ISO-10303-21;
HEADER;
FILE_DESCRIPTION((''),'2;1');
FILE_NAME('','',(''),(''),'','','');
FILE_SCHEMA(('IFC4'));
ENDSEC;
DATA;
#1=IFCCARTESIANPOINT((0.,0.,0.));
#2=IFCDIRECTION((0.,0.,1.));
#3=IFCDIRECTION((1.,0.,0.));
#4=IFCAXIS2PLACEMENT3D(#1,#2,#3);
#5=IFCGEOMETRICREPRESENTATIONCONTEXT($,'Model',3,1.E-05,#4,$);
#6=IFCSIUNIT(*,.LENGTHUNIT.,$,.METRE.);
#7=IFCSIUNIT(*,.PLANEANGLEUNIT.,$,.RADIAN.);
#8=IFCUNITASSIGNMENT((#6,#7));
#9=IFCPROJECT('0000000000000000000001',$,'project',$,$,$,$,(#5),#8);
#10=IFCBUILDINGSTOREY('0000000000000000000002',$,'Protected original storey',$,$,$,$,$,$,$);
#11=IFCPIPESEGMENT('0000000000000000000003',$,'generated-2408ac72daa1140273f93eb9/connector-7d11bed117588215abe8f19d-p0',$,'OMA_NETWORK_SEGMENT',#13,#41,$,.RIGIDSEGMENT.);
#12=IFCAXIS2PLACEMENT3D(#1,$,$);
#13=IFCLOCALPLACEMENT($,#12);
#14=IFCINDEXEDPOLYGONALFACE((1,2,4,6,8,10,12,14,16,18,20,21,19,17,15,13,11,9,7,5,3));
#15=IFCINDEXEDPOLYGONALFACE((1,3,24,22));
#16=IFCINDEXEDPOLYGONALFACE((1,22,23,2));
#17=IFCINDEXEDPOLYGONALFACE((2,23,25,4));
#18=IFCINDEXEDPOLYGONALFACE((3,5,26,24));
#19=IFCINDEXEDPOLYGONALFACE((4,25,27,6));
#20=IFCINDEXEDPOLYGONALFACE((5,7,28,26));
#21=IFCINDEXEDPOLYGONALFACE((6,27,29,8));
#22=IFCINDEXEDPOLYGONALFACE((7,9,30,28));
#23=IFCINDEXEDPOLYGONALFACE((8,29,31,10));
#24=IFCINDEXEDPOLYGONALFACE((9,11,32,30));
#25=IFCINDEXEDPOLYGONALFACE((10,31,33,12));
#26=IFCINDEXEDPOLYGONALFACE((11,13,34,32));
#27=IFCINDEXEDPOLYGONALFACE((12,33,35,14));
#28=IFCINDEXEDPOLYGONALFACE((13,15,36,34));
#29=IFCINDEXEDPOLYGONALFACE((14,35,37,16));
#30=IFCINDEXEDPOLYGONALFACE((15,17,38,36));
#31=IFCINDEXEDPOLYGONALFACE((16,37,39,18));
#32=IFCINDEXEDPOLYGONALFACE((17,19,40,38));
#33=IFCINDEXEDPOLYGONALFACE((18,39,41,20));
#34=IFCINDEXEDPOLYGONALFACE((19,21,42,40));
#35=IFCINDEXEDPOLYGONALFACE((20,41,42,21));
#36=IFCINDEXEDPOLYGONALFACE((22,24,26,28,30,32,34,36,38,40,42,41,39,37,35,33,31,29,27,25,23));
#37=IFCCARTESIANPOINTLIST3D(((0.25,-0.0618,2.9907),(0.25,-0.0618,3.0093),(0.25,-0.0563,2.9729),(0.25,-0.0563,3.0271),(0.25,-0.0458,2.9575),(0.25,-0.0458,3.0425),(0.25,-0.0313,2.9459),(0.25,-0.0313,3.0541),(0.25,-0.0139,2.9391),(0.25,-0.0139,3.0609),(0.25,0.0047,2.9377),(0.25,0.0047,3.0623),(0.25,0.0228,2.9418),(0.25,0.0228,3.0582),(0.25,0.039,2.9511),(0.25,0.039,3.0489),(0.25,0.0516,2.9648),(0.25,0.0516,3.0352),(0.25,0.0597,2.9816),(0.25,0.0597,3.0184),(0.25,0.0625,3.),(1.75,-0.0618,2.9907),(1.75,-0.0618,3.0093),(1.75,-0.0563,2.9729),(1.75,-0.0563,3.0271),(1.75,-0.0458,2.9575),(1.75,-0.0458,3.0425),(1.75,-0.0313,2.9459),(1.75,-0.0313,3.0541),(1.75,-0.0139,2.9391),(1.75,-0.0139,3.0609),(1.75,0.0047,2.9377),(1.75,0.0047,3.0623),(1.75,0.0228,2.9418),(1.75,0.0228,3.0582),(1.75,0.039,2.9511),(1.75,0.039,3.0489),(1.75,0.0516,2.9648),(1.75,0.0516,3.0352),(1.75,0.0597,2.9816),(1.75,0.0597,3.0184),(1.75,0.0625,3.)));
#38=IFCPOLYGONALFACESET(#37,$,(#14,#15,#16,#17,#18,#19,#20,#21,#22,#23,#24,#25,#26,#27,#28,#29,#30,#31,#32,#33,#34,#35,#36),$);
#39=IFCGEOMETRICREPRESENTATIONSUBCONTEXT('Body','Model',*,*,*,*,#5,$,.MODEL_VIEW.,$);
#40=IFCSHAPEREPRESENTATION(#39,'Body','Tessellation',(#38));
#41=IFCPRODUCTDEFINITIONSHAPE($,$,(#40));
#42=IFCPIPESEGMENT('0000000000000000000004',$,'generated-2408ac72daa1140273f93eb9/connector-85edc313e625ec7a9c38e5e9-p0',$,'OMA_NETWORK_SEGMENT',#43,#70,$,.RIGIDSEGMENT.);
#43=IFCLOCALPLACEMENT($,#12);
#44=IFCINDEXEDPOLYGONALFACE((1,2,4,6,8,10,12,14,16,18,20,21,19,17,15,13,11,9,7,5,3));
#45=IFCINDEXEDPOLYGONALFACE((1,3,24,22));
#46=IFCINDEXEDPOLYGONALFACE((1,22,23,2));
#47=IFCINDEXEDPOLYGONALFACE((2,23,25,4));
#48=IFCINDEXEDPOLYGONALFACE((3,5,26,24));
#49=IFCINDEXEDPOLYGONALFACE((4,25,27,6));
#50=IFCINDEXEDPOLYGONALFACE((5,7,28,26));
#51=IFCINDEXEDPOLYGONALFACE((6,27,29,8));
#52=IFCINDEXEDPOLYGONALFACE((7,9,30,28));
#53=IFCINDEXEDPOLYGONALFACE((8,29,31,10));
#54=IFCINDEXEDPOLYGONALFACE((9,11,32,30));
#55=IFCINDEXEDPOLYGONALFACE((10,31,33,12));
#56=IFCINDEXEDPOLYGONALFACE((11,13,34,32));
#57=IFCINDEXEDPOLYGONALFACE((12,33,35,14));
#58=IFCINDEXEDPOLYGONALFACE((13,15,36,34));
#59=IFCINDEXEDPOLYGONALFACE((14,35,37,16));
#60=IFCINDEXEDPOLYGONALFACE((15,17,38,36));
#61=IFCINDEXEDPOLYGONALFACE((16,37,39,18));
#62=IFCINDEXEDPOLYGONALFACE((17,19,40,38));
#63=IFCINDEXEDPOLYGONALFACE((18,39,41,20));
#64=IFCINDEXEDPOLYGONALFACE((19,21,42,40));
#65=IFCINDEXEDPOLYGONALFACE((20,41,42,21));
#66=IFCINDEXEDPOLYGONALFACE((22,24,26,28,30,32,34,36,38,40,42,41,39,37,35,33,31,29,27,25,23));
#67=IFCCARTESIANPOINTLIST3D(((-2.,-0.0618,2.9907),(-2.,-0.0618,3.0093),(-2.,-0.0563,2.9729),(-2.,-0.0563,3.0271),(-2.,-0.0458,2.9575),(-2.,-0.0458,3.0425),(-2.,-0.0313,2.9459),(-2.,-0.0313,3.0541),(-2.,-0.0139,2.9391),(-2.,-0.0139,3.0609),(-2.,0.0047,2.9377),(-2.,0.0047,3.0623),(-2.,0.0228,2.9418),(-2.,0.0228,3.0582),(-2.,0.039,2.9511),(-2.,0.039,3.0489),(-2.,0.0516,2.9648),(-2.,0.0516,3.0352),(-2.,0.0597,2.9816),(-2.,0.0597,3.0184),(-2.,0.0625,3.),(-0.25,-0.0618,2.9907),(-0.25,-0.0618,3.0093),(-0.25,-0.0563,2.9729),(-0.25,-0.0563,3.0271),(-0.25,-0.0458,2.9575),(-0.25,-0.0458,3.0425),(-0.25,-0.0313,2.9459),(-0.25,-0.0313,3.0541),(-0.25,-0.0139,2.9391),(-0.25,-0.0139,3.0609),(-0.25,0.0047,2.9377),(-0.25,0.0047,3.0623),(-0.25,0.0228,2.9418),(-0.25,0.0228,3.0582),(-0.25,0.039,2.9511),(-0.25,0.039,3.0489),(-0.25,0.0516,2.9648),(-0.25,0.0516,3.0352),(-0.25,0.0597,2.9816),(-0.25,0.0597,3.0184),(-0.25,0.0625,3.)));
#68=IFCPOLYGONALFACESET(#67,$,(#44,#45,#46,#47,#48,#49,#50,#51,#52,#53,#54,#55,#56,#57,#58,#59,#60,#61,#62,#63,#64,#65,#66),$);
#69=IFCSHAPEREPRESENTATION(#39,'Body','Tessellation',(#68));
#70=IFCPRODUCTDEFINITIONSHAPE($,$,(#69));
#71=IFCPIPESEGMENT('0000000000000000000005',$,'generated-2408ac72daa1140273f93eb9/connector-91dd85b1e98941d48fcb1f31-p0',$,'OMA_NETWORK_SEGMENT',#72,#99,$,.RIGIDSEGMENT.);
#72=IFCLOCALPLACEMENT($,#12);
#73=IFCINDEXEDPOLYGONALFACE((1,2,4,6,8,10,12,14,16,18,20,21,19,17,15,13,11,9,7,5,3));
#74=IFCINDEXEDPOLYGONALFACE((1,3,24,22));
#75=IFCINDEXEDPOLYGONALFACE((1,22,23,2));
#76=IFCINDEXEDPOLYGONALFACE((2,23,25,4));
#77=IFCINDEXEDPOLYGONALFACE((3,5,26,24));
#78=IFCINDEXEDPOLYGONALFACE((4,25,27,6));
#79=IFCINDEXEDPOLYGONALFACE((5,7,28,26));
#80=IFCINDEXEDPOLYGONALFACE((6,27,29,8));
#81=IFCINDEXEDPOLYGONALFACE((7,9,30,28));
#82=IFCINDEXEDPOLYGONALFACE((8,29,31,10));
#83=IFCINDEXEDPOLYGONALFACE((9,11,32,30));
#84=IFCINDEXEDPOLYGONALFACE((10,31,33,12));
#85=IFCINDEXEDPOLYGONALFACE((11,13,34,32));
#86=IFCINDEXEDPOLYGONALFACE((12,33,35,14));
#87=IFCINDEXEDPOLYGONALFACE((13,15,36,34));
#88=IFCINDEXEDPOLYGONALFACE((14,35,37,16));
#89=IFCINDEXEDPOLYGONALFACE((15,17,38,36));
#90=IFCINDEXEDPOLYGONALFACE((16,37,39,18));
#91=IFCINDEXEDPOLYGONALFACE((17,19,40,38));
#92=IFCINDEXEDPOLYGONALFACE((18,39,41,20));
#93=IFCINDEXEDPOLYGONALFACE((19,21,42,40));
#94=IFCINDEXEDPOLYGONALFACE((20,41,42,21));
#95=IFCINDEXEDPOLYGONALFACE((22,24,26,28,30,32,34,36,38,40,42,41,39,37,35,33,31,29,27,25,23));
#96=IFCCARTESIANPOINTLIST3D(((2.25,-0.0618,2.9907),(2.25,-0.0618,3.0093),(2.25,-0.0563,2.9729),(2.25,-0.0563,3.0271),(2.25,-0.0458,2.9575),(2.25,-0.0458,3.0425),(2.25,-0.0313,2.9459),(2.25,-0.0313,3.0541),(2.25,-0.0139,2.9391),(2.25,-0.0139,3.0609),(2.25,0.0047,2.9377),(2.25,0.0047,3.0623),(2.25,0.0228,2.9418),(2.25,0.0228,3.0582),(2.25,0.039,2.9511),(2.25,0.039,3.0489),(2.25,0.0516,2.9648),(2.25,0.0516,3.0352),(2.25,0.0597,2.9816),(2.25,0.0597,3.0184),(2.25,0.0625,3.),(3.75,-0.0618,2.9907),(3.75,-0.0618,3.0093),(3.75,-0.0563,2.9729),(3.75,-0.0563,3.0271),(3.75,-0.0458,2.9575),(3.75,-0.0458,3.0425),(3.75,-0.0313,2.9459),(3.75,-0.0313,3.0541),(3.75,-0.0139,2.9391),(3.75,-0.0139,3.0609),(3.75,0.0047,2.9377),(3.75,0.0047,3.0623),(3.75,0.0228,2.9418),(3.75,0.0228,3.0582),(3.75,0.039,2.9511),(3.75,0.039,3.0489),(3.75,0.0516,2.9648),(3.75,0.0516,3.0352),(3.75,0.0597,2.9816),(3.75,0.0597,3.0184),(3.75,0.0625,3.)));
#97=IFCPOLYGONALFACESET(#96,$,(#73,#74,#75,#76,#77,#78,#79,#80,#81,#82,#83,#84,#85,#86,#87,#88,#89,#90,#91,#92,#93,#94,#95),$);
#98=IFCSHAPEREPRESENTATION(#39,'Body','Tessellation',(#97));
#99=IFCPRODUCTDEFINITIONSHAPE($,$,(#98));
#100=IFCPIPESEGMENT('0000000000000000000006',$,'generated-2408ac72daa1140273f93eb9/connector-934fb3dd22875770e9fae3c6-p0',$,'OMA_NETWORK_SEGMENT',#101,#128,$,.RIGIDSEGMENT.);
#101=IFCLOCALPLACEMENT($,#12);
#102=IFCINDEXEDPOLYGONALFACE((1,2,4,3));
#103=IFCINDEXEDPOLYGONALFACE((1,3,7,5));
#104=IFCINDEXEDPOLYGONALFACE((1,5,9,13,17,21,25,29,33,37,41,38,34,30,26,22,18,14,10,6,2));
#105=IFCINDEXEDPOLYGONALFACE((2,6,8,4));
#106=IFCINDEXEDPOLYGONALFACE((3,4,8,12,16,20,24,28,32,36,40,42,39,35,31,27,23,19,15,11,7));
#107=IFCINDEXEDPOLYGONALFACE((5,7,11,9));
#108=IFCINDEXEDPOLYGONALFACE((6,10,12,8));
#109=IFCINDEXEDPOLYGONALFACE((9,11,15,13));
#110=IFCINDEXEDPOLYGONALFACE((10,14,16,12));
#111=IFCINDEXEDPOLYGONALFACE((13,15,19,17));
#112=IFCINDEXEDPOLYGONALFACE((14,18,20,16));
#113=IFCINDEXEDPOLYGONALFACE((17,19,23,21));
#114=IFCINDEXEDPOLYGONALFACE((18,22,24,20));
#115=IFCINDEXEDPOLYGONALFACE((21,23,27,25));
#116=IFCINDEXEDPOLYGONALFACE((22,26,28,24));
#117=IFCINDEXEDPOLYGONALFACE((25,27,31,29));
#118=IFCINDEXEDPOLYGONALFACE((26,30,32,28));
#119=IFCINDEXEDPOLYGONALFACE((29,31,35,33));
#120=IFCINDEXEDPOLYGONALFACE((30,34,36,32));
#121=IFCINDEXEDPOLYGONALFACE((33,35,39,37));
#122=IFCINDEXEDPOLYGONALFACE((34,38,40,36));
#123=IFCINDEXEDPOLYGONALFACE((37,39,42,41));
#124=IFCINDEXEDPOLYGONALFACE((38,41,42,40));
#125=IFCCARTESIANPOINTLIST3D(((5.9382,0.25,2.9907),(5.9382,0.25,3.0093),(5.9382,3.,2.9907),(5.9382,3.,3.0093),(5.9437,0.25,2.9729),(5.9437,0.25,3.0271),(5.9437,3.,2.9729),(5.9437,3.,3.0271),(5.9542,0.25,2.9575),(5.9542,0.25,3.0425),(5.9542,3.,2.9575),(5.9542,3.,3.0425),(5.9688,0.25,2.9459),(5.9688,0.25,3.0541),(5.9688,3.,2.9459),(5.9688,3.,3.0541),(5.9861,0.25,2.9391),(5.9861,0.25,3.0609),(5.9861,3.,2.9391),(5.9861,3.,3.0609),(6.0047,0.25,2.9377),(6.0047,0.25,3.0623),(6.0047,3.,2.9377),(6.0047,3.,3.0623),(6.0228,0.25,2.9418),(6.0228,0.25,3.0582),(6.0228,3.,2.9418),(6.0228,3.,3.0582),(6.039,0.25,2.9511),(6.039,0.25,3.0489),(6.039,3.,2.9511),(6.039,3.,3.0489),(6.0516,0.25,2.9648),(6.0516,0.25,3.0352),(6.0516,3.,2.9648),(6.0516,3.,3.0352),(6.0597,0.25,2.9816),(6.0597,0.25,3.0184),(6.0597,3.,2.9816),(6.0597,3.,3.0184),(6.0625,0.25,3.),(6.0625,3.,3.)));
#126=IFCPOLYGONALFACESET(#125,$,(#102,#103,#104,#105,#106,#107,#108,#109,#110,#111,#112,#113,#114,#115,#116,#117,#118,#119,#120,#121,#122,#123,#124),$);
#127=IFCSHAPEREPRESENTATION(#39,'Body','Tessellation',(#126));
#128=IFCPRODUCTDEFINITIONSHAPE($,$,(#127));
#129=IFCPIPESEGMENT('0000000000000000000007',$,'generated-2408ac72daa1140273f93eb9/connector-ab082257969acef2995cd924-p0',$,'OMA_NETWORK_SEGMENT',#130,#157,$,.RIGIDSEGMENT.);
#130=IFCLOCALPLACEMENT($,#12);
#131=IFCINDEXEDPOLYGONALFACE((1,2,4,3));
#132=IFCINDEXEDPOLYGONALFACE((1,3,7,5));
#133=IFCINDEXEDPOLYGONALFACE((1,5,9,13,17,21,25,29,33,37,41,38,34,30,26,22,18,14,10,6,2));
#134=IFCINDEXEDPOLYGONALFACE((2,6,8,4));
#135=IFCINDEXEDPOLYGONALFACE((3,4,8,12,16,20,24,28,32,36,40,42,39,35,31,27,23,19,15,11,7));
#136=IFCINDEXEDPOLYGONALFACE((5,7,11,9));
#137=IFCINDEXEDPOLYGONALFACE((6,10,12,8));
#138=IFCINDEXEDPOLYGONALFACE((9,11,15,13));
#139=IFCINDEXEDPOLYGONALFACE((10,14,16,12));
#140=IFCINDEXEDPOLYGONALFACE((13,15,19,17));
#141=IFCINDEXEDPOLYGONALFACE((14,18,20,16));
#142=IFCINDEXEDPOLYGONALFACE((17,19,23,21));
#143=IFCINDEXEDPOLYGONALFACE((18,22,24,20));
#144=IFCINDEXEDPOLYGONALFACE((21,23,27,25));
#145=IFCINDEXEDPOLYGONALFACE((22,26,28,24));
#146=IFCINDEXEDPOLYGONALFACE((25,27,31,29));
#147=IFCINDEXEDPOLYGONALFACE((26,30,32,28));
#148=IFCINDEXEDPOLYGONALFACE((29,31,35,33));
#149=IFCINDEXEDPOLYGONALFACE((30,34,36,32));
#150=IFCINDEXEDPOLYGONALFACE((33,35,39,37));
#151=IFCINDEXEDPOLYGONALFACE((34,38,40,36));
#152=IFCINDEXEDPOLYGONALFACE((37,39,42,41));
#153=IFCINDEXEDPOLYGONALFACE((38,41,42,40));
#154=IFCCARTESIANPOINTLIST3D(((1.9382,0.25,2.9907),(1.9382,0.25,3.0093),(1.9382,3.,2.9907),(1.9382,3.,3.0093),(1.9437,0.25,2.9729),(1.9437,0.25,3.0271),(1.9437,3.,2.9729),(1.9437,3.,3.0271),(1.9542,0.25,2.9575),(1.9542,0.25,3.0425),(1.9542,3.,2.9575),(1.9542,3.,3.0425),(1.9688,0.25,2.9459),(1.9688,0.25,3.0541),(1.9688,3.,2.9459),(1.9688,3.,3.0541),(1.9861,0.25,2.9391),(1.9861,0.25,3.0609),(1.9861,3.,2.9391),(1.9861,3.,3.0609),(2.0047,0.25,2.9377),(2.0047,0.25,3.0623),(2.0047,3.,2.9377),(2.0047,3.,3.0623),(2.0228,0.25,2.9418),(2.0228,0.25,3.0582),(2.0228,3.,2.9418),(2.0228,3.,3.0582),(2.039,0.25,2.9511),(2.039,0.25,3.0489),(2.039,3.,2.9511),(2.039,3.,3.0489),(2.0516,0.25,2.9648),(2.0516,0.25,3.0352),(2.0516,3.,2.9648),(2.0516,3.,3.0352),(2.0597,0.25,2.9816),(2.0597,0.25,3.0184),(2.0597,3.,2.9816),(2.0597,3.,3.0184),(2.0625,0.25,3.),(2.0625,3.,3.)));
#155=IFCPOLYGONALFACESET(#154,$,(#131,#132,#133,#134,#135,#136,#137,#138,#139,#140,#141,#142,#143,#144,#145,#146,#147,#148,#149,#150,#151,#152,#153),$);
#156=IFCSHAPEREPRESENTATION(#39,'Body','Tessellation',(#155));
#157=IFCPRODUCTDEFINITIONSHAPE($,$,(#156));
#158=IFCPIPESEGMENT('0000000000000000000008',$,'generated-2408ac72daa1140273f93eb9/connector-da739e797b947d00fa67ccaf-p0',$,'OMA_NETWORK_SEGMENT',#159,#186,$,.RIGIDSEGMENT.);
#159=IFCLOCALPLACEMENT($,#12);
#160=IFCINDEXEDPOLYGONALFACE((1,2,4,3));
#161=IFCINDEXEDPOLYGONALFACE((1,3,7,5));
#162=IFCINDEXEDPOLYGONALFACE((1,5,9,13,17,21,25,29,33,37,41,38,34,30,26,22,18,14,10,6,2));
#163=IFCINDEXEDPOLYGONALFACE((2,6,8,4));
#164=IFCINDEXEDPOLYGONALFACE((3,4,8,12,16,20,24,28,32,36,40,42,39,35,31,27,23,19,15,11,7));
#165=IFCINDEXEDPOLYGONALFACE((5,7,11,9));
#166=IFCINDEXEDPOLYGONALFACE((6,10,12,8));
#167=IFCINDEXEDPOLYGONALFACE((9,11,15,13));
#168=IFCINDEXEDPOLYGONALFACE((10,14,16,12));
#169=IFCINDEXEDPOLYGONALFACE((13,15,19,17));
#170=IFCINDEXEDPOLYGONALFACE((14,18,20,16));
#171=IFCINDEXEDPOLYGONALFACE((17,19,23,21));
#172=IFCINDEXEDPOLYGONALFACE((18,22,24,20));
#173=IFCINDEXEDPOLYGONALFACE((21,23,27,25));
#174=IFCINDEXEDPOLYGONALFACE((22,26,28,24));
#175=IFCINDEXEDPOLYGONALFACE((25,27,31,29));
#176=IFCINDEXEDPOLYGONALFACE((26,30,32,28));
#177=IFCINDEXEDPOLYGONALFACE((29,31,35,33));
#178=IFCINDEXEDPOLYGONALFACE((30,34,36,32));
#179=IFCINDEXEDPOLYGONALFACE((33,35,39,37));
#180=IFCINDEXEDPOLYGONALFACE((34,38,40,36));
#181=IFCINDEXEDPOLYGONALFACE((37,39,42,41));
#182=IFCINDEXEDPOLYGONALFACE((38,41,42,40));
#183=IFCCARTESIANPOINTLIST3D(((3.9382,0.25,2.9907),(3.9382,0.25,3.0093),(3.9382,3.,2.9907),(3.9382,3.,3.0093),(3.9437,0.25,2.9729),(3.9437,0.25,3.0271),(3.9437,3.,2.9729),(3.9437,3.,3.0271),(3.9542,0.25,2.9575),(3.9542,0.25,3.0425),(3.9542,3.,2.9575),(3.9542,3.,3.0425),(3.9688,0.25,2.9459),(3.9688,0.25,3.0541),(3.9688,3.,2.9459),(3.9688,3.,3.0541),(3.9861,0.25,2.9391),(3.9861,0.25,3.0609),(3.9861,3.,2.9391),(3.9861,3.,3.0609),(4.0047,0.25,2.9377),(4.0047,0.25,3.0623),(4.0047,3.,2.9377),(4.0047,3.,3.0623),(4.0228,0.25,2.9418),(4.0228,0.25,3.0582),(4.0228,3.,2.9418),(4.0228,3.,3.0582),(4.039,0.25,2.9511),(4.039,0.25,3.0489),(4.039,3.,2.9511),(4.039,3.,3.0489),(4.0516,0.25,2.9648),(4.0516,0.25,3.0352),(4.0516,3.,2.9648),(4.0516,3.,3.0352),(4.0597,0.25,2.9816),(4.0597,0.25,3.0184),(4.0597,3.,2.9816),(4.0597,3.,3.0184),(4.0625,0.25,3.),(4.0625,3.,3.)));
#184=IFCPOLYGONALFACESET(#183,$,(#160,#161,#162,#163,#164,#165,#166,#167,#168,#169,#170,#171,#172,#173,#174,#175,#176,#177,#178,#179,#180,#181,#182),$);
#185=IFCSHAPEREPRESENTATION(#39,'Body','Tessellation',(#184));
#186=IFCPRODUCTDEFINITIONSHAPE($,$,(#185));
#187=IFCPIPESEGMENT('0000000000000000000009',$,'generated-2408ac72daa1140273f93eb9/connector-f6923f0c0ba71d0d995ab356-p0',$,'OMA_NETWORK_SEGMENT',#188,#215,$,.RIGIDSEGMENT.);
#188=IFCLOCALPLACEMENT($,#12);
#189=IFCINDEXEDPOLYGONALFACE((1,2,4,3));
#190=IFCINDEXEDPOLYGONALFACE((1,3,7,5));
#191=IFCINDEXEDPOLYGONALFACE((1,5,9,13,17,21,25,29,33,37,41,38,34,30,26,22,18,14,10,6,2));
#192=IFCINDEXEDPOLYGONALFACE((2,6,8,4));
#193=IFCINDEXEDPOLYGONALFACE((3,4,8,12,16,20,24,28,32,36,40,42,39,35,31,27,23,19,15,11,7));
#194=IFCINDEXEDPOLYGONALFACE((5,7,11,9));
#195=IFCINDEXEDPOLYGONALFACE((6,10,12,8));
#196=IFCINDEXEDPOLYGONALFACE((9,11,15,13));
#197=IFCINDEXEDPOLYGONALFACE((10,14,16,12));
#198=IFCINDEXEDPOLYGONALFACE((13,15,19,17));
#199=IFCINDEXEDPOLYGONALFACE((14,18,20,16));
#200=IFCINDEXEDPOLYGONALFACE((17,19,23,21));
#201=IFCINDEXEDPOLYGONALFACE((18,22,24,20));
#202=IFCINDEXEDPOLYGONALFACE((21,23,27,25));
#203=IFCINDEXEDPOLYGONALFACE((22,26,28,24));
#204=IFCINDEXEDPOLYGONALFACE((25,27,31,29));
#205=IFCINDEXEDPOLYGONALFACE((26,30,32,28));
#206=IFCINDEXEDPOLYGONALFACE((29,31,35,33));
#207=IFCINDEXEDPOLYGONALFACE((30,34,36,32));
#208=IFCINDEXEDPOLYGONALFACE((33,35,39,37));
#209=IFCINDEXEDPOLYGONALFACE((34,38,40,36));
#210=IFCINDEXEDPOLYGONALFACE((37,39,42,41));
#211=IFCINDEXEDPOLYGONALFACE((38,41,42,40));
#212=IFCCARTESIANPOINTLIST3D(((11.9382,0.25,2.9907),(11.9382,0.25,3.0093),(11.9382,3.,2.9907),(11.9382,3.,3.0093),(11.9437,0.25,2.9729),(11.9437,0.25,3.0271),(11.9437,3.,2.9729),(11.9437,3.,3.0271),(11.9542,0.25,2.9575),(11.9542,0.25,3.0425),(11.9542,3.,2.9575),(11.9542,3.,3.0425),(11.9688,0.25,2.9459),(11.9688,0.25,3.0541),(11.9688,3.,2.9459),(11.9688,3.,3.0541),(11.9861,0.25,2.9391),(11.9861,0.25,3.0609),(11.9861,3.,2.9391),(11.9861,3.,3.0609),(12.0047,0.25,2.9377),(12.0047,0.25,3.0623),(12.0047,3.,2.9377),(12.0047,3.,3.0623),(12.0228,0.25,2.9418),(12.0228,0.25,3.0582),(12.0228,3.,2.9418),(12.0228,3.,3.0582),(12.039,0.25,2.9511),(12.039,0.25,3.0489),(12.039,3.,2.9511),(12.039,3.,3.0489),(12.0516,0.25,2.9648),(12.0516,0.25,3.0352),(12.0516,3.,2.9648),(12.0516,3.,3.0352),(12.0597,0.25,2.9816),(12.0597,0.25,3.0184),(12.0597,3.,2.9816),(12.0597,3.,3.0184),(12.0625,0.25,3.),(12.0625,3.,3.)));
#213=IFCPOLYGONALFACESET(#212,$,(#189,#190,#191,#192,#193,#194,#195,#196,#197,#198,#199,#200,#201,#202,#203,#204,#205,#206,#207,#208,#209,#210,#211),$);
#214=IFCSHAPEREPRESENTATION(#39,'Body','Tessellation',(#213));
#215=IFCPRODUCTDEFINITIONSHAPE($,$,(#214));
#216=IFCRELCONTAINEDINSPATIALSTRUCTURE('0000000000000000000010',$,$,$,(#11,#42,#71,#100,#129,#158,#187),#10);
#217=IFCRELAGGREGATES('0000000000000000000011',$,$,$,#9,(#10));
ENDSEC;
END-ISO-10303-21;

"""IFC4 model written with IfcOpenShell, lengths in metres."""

from ifc_helpers import new_model, si_unit, frame, origin_with_axes, origin_2d, place, context, subcontext, project, spatial, circle, extrude, element, save


model = new_model("IFC4")

# Units and contexts
model_context = context("Model", 3, precision=1e-05, world=origin_with_axes())
body_context = subcontext(model_context, "Body", "Model", "MODEL_VIEW")
ifc_project = project(units=[si_unit("LENGTHUNIT", "METRE"), si_unit("PLANEANGLEUNIT", "RADIAN")], contexts=[model_context])

# Storey
storey = spatial("IfcBuildingStorey", under=ifc_project, Name="Protected original storey")

# Pipe segments
pipe_segment_1_placement = place(None, origin_with_axes())
element("IfcPipeSegment", 1, at=pipe_segment_1_placement, inside=storey, Name="generated-2408ac72daa1140273f93eb9/connector-7d11bed117588215abe8f19d-p0", ObjectType="OMA_NETWORK_SEGMENT", PredefinedType="RIGIDSEGMENT", context=body_context, shape_type="SweptSolid", body=[
    extrude(circle(Radius=0.0625, at=origin_2d()), frame((0.25, 0.0, 3.0), z_axis=(1.0, 0.0, 0.0), x_axis=(0.0, 1.0, 0.0)), (0.0, 0.0, 1.0), 1.5),
])
pipe_segment_2_placement = place(None, origin_with_axes())
element("IfcPipeSegment", 2, at=pipe_segment_2_placement, inside=storey, Name="generated-2408ac72daa1140273f93eb9/connector-85edc313e625ec7a9c38e5e9-p0", ObjectType="OMA_NETWORK_SEGMENT", PredefinedType="RIGIDSEGMENT", context=body_context, shape_type="SweptSolid", body=[
    extrude(circle(Radius=0.0625, at=origin_2d()), frame((-2.0, 0.0, 3.0), z_axis=(1.0, 0.0, 0.0), x_axis=(0.0, 1.0, 0.0)), (0.0, 0.0, 1.0), 1.75),
])
pipe_segment_3_placement = place(None, origin_with_axes())
element("IfcPipeSegment", 3, at=pipe_segment_3_placement, inside=storey, Name="generated-2408ac72daa1140273f93eb9/connector-91dd85b1e98941d48fcb1f31-p0", ObjectType="OMA_NETWORK_SEGMENT", PredefinedType="RIGIDSEGMENT", context=body_context, shape_type="SweptSolid", body=[
    extrude(circle(Radius=0.0625, at=origin_2d()), frame((2.25, 0.0, 3.0), z_axis=(1.0, 0.0, 0.0), x_axis=(0.0, 1.0, 0.0)), (0.0, 0.0, 1.0), 1.5),
])
pipe_segment_4_placement = place(None, origin_with_axes())
element("IfcPipeSegment", 4, at=pipe_segment_4_placement, inside=storey, Name="generated-2408ac72daa1140273f93eb9/connector-934fb3dd22875770e9fae3c6-p0", ObjectType="OMA_NETWORK_SEGMENT", PredefinedType="RIGIDSEGMENT", context=body_context, shape_type="SweptSolid", body=[
    extrude(circle(Radius=0.0625, at=origin_2d()), frame((6.0, 0.25, 3.0), z_axis=(0.0, 1.0, 0.0), x_axis=(1.0, 0.0, 0.0)), (0.0, 0.0, 1.0), 2.75),
])
pipe_segment_5_placement = place(None, origin_with_axes())
element("IfcPipeSegment", 5, at=pipe_segment_5_placement, inside=storey, Name="generated-2408ac72daa1140273f93eb9/connector-ab082257969acef2995cd924-p0", ObjectType="OMA_NETWORK_SEGMENT", PredefinedType="RIGIDSEGMENT", context=body_context, shape_type="SweptSolid", body=[
    extrude(circle(Radius=0.0625, at=origin_2d()), frame((2.0, 0.25, 3.0), z_axis=(0.0, 1.0, 0.0), x_axis=(1.0, 0.0, 0.0)), (0.0, 0.0, 1.0), 2.75),
])
pipe_segment_6_placement = place(None, origin_with_axes())
element("IfcPipeSegment", 6, at=pipe_segment_6_placement, inside=storey, Name="generated-2408ac72daa1140273f93eb9/connector-da739e797b947d00fa67ccaf-p0", ObjectType="OMA_NETWORK_SEGMENT", PredefinedType="RIGIDSEGMENT", context=body_context, shape_type="SweptSolid", body=[
    extrude(circle(Radius=0.0625, at=origin_2d()), frame((4.0, 0.25, 3.0), z_axis=(0.0, 1.0, 0.0), x_axis=(1.0, 0.0, 0.0)), (0.0, 0.0, 1.0), 2.75),
])
pipe_segment_7_placement = place(None, origin_with_axes())
element("IfcPipeSegment", 7, at=pipe_segment_7_placement, inside=storey, Name="generated-2408ac72daa1140273f93eb9/connector-f6923f0c0ba71d0d995ab356-p0", ObjectType="OMA_NETWORK_SEGMENT", PredefinedType="RIGIDSEGMENT", context=body_context, shape_type="SweptSolid", body=[
    extrude(circle(Radius=0.0625, at=origin_2d()), frame((12.0, 0.25, 3.0), z_axis=(0.0, 1.0, 0.0), x_axis=(1.0, 0.0, 0.0)), (0.0, 0.0, 1.0), 2.75),
])

save(model, "model.ifc")
